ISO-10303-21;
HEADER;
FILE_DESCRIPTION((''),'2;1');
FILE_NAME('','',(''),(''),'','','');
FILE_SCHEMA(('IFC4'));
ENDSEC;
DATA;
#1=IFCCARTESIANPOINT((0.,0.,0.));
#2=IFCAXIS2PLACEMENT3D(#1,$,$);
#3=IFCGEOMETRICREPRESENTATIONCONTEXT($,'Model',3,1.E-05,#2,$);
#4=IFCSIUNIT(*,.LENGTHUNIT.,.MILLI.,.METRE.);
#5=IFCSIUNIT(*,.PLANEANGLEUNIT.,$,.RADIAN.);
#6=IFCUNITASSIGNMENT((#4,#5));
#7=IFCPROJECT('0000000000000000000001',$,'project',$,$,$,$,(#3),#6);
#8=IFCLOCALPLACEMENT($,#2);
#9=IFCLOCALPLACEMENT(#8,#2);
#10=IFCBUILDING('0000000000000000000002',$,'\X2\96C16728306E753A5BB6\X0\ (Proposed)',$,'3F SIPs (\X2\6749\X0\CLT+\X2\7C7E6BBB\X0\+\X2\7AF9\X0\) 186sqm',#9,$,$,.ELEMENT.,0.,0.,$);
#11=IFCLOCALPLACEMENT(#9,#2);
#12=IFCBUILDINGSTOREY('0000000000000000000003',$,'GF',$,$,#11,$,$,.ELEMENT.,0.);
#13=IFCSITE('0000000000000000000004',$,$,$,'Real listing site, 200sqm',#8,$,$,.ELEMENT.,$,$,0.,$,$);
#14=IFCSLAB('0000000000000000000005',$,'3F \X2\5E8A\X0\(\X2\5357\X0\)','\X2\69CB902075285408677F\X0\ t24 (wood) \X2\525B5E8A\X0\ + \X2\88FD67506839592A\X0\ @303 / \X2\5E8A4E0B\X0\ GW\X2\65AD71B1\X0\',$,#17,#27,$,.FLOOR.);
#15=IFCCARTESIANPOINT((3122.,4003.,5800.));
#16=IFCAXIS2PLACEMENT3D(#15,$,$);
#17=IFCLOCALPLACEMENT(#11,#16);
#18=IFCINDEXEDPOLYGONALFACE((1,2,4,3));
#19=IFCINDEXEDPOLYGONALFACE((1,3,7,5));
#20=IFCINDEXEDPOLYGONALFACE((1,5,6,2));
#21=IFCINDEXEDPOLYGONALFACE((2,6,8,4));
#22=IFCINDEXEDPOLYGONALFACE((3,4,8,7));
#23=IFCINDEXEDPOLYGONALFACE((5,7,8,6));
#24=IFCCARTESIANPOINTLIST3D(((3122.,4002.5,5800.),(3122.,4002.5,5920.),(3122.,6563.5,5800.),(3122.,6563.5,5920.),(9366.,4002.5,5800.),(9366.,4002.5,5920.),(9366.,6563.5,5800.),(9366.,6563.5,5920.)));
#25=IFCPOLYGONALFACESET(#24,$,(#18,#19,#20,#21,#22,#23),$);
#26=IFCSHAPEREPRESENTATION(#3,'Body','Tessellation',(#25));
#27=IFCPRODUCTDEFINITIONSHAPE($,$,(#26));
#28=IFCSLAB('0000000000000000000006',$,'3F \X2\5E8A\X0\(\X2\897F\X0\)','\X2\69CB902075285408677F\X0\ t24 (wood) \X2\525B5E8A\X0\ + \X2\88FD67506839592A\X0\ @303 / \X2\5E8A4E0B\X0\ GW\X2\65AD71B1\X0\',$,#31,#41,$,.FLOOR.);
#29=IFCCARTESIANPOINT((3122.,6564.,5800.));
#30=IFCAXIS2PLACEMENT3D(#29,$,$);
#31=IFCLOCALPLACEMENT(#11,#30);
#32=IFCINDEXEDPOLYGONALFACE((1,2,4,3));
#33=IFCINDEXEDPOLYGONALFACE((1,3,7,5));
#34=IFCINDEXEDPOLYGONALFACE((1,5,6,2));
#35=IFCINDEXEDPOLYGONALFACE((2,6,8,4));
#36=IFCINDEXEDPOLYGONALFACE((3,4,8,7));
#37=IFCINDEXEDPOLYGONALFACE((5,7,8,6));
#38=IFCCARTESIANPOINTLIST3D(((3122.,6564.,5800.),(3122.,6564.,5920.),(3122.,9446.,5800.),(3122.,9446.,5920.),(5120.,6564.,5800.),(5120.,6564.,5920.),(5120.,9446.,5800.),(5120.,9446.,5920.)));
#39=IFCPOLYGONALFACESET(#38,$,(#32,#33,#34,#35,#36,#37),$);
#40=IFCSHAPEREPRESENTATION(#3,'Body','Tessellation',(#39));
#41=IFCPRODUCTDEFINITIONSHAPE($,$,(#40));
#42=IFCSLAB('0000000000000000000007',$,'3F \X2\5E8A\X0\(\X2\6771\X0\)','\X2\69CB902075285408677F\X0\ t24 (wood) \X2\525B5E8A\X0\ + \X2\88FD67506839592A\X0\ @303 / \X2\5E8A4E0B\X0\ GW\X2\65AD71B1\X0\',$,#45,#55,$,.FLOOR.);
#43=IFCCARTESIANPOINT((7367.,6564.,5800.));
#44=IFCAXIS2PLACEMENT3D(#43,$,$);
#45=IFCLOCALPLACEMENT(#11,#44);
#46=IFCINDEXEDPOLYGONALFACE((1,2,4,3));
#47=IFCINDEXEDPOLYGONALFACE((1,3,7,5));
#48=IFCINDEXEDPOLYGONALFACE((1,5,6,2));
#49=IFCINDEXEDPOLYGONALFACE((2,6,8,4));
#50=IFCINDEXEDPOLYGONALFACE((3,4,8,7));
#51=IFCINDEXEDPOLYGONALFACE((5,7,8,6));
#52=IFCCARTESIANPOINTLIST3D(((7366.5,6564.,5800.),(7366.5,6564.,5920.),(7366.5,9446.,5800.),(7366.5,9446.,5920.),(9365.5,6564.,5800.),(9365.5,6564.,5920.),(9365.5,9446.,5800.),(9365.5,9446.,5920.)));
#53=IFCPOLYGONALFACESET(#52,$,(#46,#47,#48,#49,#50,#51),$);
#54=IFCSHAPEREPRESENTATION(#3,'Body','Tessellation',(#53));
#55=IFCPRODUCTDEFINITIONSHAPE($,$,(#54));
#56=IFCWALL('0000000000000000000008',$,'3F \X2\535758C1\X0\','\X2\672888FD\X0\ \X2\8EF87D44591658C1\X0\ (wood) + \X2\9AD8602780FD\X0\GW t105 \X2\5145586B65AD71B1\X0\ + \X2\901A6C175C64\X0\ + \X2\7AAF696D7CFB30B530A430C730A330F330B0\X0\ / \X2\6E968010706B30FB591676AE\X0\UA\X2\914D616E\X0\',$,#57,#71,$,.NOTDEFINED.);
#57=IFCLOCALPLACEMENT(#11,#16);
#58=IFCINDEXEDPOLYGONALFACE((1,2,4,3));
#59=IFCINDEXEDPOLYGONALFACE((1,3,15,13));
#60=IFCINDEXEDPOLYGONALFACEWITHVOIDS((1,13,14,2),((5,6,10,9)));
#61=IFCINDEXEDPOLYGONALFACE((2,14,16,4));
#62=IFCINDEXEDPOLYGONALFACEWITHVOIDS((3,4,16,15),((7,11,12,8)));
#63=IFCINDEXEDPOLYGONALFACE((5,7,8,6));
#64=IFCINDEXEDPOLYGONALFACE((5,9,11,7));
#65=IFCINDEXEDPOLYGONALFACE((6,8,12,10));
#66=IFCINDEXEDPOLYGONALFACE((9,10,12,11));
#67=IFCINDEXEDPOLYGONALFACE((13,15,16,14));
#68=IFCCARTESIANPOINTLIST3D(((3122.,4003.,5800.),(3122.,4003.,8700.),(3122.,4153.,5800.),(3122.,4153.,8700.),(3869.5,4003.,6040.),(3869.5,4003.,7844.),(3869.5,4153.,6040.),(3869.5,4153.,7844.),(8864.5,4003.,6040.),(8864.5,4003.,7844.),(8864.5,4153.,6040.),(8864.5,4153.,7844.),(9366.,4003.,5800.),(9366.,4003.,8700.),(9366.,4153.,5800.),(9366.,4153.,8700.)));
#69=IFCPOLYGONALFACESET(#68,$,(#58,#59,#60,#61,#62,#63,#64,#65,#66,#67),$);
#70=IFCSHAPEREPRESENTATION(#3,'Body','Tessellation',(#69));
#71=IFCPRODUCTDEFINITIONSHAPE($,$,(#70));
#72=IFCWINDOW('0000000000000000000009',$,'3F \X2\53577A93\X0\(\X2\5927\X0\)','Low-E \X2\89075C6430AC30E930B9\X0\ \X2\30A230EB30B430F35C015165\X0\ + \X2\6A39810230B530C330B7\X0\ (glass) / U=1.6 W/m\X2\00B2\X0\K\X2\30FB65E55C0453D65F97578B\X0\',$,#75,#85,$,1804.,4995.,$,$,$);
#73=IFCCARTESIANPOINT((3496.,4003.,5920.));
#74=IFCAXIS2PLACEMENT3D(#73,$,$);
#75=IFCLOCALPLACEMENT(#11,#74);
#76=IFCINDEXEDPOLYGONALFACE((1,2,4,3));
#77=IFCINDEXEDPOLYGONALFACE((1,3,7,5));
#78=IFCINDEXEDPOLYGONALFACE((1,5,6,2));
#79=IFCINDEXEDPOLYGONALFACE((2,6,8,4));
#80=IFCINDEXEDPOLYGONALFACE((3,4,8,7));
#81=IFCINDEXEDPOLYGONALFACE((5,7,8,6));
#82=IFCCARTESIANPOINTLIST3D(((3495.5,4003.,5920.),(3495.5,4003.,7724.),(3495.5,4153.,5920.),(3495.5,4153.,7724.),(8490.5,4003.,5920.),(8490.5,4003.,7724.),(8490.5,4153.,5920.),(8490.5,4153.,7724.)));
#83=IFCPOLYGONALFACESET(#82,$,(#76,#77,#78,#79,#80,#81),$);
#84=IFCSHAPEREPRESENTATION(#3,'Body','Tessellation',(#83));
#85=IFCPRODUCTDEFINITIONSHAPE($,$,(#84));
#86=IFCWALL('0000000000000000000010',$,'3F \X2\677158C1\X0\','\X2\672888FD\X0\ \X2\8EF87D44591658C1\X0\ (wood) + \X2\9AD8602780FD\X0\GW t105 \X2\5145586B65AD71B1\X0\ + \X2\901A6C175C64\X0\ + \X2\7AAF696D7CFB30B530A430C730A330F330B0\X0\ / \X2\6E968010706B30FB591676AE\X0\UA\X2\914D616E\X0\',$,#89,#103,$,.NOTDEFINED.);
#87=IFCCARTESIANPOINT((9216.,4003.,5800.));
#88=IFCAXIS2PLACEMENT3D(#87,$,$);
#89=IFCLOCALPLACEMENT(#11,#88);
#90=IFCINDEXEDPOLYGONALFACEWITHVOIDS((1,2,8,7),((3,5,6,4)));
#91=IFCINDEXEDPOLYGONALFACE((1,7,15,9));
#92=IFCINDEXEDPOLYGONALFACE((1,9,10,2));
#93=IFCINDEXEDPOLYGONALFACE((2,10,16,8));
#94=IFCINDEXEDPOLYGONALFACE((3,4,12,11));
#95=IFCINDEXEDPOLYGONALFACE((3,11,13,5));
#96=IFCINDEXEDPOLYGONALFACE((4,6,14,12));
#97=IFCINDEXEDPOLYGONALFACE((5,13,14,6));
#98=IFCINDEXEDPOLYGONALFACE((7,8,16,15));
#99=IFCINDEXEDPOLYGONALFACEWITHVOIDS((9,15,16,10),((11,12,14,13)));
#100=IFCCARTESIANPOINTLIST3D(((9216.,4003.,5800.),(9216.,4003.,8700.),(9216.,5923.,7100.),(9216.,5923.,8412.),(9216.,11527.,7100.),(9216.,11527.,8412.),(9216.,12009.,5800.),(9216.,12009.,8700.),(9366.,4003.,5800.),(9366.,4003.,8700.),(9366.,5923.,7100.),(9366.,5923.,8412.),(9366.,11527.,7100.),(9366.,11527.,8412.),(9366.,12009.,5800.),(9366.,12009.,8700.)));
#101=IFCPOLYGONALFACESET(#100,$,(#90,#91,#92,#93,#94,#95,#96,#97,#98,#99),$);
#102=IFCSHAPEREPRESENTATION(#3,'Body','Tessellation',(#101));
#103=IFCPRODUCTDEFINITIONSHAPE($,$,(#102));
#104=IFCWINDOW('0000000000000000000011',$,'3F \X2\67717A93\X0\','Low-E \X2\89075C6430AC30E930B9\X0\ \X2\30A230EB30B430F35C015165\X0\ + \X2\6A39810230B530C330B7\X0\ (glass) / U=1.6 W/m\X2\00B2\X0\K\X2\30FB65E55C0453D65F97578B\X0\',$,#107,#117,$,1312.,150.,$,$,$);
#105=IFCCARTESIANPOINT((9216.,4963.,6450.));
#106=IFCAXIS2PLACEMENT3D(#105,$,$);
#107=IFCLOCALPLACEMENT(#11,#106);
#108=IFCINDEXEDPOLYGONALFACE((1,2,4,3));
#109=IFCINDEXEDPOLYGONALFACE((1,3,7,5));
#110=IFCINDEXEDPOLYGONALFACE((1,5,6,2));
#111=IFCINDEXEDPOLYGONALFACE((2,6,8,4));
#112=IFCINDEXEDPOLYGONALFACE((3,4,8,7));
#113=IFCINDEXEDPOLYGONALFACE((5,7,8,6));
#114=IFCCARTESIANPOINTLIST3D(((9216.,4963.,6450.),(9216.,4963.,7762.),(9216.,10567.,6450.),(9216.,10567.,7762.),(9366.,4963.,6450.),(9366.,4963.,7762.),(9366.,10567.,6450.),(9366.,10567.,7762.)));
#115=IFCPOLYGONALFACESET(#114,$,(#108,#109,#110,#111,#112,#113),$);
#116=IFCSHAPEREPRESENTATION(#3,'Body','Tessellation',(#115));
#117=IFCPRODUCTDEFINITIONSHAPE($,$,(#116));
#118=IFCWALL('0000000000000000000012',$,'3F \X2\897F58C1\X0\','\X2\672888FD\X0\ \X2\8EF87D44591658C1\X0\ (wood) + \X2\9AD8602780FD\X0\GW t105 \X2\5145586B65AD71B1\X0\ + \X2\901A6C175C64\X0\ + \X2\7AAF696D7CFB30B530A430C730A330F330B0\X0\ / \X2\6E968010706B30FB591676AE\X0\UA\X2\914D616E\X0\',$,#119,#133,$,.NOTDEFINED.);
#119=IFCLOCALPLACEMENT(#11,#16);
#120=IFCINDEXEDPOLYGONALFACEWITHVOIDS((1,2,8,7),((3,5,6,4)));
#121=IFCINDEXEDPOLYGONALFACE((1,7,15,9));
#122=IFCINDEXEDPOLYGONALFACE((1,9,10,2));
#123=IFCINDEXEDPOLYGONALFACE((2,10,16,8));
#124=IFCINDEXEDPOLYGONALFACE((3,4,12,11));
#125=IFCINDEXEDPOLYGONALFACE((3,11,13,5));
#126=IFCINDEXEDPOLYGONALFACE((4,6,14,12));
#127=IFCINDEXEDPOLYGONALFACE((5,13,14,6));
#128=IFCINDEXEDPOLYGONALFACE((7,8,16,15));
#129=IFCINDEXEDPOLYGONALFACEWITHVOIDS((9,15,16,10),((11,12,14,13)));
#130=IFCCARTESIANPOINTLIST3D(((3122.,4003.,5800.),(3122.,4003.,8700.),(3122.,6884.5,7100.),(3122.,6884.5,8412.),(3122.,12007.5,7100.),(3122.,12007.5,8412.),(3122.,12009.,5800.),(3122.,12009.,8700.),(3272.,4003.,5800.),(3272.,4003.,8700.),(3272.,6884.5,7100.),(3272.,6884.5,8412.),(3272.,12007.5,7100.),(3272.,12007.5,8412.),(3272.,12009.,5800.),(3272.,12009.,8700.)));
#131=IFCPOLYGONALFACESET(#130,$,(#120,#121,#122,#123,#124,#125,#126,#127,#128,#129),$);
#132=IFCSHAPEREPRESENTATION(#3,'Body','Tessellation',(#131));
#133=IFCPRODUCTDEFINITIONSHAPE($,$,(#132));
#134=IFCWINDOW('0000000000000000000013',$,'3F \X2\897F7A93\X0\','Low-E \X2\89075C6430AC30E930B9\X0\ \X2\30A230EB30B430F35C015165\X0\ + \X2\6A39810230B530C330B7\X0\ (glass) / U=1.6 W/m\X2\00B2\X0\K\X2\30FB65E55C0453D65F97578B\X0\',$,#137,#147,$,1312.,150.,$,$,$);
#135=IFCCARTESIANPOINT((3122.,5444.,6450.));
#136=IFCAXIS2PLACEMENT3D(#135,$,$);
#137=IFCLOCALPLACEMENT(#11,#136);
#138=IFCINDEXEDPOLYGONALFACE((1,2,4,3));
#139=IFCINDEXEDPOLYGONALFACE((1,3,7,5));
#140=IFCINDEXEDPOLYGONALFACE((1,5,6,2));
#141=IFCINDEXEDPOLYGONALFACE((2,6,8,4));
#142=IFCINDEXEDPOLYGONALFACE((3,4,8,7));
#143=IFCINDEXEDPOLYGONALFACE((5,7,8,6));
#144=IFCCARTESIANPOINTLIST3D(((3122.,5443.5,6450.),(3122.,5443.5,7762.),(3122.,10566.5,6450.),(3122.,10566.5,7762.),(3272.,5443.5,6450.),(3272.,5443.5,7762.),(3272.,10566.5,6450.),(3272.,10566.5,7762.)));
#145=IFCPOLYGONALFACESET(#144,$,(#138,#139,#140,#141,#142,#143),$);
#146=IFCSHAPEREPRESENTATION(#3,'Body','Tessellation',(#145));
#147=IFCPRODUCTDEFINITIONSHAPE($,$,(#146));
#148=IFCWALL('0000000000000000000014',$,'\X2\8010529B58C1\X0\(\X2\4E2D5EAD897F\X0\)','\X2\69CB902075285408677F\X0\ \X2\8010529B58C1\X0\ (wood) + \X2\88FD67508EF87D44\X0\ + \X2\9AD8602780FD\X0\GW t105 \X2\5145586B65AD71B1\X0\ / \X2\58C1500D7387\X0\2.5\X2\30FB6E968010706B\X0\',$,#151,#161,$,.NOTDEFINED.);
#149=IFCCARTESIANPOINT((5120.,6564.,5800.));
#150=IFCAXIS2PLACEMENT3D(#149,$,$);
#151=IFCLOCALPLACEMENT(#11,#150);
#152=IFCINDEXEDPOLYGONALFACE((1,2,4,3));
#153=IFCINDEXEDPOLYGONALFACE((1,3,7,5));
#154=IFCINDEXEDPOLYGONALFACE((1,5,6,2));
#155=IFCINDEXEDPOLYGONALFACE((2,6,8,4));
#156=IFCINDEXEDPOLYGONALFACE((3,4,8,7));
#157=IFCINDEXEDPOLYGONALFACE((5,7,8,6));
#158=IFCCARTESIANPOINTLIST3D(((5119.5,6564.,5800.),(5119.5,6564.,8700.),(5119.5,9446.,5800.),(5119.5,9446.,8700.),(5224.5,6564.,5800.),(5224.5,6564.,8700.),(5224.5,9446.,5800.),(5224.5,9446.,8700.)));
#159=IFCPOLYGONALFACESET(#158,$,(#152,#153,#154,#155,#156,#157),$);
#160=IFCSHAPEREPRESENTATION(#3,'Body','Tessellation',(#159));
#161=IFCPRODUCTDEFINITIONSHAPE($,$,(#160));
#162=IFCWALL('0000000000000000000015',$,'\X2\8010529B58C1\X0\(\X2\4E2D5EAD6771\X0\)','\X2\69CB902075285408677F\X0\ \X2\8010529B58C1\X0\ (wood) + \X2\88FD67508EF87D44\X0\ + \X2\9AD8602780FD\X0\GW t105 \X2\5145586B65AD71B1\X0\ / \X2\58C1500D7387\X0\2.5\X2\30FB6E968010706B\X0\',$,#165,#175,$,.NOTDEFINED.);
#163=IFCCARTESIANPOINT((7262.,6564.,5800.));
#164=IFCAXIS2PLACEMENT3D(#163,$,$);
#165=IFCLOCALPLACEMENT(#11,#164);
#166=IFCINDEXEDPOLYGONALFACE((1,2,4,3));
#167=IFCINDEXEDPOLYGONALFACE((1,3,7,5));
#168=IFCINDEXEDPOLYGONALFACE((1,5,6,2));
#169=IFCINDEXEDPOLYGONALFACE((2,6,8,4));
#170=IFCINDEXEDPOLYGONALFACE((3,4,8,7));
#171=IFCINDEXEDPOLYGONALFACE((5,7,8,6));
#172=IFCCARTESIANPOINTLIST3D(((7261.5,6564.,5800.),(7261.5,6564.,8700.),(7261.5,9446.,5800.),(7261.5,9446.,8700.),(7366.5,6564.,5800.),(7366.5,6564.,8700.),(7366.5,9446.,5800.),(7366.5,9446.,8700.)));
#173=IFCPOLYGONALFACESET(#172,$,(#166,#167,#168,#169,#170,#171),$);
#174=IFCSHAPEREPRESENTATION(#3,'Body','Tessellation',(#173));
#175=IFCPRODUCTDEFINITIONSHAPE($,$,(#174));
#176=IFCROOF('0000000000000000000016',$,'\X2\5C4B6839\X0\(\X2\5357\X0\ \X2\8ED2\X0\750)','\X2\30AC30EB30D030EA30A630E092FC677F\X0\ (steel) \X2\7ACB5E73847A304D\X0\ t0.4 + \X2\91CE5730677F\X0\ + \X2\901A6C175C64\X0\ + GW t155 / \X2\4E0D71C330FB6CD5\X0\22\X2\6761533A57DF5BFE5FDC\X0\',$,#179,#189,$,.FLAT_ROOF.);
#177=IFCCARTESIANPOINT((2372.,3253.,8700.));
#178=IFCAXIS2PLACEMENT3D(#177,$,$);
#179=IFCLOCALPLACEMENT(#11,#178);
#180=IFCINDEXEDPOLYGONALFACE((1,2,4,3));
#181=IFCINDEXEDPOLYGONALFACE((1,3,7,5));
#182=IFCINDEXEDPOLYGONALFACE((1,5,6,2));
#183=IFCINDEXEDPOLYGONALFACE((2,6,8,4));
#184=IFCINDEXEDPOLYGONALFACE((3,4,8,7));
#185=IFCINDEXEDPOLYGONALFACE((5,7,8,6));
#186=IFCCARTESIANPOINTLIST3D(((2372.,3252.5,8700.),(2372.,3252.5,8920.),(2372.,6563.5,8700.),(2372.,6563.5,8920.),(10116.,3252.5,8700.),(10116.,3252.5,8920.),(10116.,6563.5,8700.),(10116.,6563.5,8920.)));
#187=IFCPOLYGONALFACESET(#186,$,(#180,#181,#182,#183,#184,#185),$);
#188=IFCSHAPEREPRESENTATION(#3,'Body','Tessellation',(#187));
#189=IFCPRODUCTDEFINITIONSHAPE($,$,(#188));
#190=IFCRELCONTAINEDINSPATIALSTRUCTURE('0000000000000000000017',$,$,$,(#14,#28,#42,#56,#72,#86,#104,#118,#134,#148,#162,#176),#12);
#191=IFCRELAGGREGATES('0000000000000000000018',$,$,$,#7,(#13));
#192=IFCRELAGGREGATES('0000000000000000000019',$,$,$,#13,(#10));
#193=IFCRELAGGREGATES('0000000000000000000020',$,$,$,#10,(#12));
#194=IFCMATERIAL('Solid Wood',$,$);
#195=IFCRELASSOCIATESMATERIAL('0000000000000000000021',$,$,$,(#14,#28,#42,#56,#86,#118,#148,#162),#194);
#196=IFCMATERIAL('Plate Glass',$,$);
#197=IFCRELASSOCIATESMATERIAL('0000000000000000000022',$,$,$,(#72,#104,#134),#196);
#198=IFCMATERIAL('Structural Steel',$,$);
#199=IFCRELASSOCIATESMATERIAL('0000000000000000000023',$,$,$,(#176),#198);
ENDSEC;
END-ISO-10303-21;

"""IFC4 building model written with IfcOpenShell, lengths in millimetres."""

from ifc_helpers import new_model, si_unit, frame, frame_2d, origin, place, context, project, spatial, rectangle, extrude, material, element, fill, save


model = new_model("IFC4")

# Units and contexts
model_context = context("Model", 3, precision=1e-05, world=origin())
ifc_project = project(units=[si_unit("LENGTHUNIT", "METRE", prefix="MILLI"), si_unit("PLANEANGLEUNIT", "RADIAN")], contexts=[model_context])

# Site, building, storey
site_placement = place(None, origin())
site = spatial("IfcSite", under=ifc_project, at=site_placement, ObjectType="Real listing site, 200sqm", CompositionType="ELEMENT", RefElevation=0.0)
building_placement = place(site_placement, origin())
building = spatial("IfcBuilding", under=site, at=building_placement, Name="雁木の町家 (Proposed)", ObjectType="3F SIPs (杉CLT+籾殻+竹) 186sqm", CompositionType="ELEMENT", ElevationOfRefHeight=0.0, ElevationOfTerrain=0.0)
storey_placement = place(building_placement, origin())
storey = spatial("IfcBuildingStorey", under=building, at=storey_placement, Name="GF", CompositionType="ELEMENT", Elevation=0.0)

# Slabs
ifc_material_1 = material(Name="Solid Wood")
slab_1_placement = place(storey_placement, frame((3122.0, 4003.0, 5800.0)))
element("IfcSlab", 1, at=slab_1_placement, inside=storey, material=ifc_material_1, Name="3F 床(南)", Description="構造用合板 t24 (wood) 剛床 + 製材根太 @303 / 床下 GW断熱", PredefinedType="FLOOR", context=model_context, shape_type="SweptSolid", body=[
    extrude(rectangle(XDim=6244.0, YDim=2561.0, at=frame_2d((3122.0, 1280.0))), frame((3122.0, 4003.0, 5800.0)), (0.0, 0.0, 1.0), 120.0),
])
slab_2_placement = place(storey_placement, frame((3122.0, 6564.0, 5800.0)))
element("IfcSlab", 2, at=slab_2_placement, inside=storey, material=ifc_material_1, Name="3F 床(西)", Description="構造用合板 t24 (wood) 剛床 + 製材根太 @303 / 床下 GW断熱", PredefinedType="FLOOR", context=model_context, shape_type="SweptSolid", body=[
    extrude(rectangle(XDim=1998.0, YDim=2882.0, at=frame_2d((999.0, 1441.0))), frame((3122.0, 6564.0, 5800.0)), (0.0, 0.0, 1.0), 120.0),
])
slab_3_placement = place(storey_placement, frame((7367.0, 6564.0, 5800.0)))
element("IfcSlab", 3, at=slab_3_placement, inside=storey, material=ifc_material_1, Name="3F 床(東)", Description="構造用合板 t24 (wood) 剛床 + 製材根太 @303 / 床下 GW断熱", PredefinedType="FLOOR", context=model_context, shape_type="SweptSolid", body=[
    extrude(rectangle(XDim=1999.0, YDim=2882.0, at=frame_2d((999.0, 1441.0))), frame((7367.0, 6564.0, 5800.0)), (0.0, 0.0, 1.0), 120.0),
])

# Walls, openings, windows
wall_1_placement = place(storey_placement, frame((3122.0, 4003.0, 5800.0)))
wall_1 = element("IfcWall", 4, at=wall_1_placement, inside=storey, material=ifc_material_1, Name="3F 南壁", Description="木製 軸組外壁 (wood) + 高性能GW t105 充填断熱 + 通気層 + 窯業系サイディング / 準耐火・外皮UA配慮", PredefinedType="NOTDEFINED", context=model_context, shape_type="SweptSolid", body=[
    extrude(rectangle(XDim=6244.0, YDim=150.0, at=frame_2d((3122.0, 75.0))), frame((3122.0, 4003.0, 5800.0)), (0.0, 0.0, 1.0), 2900.0),
])
opening_1_placement = place(storey_placement, frame((3496.0, 4003.0, 5920.0)))
opening_1 = element("IfcOpeningElement", 5, at=opening_1_placement, cuts=wall_1, PredefinedType="NOTDEFINED", context=model_context, shape_type="SweptSolid", body=[
    extrude(rectangle(XDim=4995.0, YDim=150.0, at=frame_2d((2497.0, 75.0))), frame((3496.0, 4003.0, 5920.0)), (0.0, 0.0, 1.0), 1804.0),
])
ifc_material_2 = material(Name="Plate Glass")
window_1_placement = place(storey_placement, frame((3496.0, 4003.0, 5920.0)))
window_1 = element("IfcWindow", 6, at=window_1_placement, inside=storey, material=ifc_material_2, Name="3F 南窓(大)", Description="Low-E 複層ガラス アルゴン封入 + 樹脂サッシ (glass) / U=1.6 W/m²K・日射取得型", OverallHeight=1804.0, OverallWidth=4995.0, context=model_context, shape_type="SweptSolid", body=[
    extrude(rectangle(XDim=4995.0, YDim=150.0, at=frame_2d((2497.0, 75.0))), frame((3496.0, 4003.0, 5920.0)), (0.0, 0.0, 1.0), 1804.0),
])
fill(opening_1, window_1)
wall_2_placement = place(storey_placement, frame((9216.0, 4003.0, 5800.0)))
wall_2 = element("IfcWall", 7, at=wall_2_placement, inside=storey, material=ifc_material_1, Name="3F 東壁", Description="木製 軸組外壁 (wood) + 高性能GW t105 充填断熱 + 通気層 + 窯業系サイディング / 準耐火・外皮UA配慮", PredefinedType="NOTDEFINED", context=model_context, shape_type="SweptSolid", body=[
    extrude(rectangle(XDim=150.0, YDim=8006.0, at=frame_2d((75.0, 4003.0))), frame((9216.0, 4003.0, 5800.0)), (0.0, 0.0, 1.0), 2900.0),
])
opening_2_placement = place(storey_placement, frame((9216.0, 4963.0, 6450.0)))
opening_2 = element("IfcOpeningElement", 8, at=opening_2_placement, cuts=wall_2, PredefinedType="NOTDEFINED", context=model_context, shape_type="SweptSolid", body=[
    extrude(rectangle(XDim=150.0, YDim=5604.0, at=frame_2d((75.0, 2802.0))), frame((9216.0, 4963.0, 6450.0)), (0.0, 0.0, 1.0), 1312.0),
])
window_2_placement = place(storey_placement, frame((9216.0, 4963.0, 6450.0)))
window_2 = element("IfcWindow", 9, at=window_2_placement, inside=storey, material=ifc_material_2, Name="3F 東窓", Description="Low-E 複層ガラス アルゴン封入 + 樹脂サッシ (glass) / U=1.6 W/m²K・日射取得型", OverallHeight=1312.0, OverallWidth=150.0, context=model_context, shape_type="SweptSolid", body=[
    extrude(rectangle(XDim=150.0, YDim=5604.0, at=frame_2d((75.0, 2802.0))), frame((9216.0, 4963.0, 6450.0)), (0.0, 0.0, 1.0), 1312.0),
])
fill(opening_2, window_2)
wall_3_placement = place(storey_placement, frame((3122.0, 4003.0, 5800.0)))
wall_3 = element("IfcWall", 10, at=wall_3_placement, inside=storey, material=ifc_material_1, Name="3F 西壁", Description="木製 軸組外壁 (wood) + 高性能GW t105 充填断熱 + 通気層 + 窯業系サイディング / 準耐火・外皮UA配慮", PredefinedType="NOTDEFINED", context=model_context, shape_type="SweptSolid", body=[
    extrude(rectangle(XDim=150.0, YDim=8006.0, at=frame_2d((75.0, 4003.0))), frame((3122.0, 4003.0, 5800.0)), (0.0, 0.0, 1.0), 2900.0),
])
opening_3_placement = place(storey_placement, frame((3122.0, 5444.0, 6450.0)))
opening_3 = element("IfcOpeningElement", 11, at=opening_3_placement, cuts=wall_3, PredefinedType="NOTDEFINED", context=model_context, shape_type="SweptSolid", body=[
    extrude(rectangle(XDim=150.0, YDim=5123.0, at=frame_2d((75.0, 2561.0))), frame((3122.0, 5444.0, 6450.0)), (0.0, 0.0, 1.0), 1312.0),
])
window_3_placement = place(storey_placement, frame((3122.0, 5444.0, 6450.0)))
window_3 = element("IfcWindow", 12, at=window_3_placement, inside=storey, material=ifc_material_2, Name="3F 西窓", Description="Low-E 複層ガラス アルゴン封入 + 樹脂サッシ (glass) / U=1.6 W/m²K・日射取得型", OverallHeight=1312.0, OverallWidth=150.0, context=model_context, shape_type="SweptSolid", body=[
    extrude(rectangle(XDim=150.0, YDim=5123.0, at=frame_2d((75.0, 2561.0))), frame((3122.0, 5444.0, 6450.0)), (0.0, 0.0, 1.0), 1312.0),
])
fill(opening_3, window_3)

# Walls
wall_4_placement = place(storey_placement, frame((5120.0, 6564.0, 5800.0)))
element("IfcWall", 13, at=wall_4_placement, inside=storey, material=ifc_material_1, Name="耐力壁(中庭西)", Description="構造用合板 耐力壁 (wood) + 製材軸組 + 高性能GW t105 充填断熱 / 壁倍率2.5・準耐火", PredefinedType="NOTDEFINED", context=model_context, shape_type="SweptSolid", body=[
    extrude(rectangle(XDim=105.0, YDim=2882.0, at=frame_2d((52.0, 1441.0))), frame((5120.0, 6564.0, 5800.0)), (0.0, 0.0, 1.0), 2900.0),
])
wall_5_placement = place(storey_placement, frame((7262.0, 6564.0, 5800.0)))
element("IfcWall", 14, at=wall_5_placement, inside=storey, material=ifc_material_1, Name="耐力壁(中庭東)", Description="構造用合板 耐力壁 (wood) + 製材軸組 + 高性能GW t105 充填断熱 / 壁倍率2.5・準耐火", PredefinedType="NOTDEFINED", context=model_context, shape_type="SweptSolid", body=[
    extrude(rectangle(XDim=105.0, YDim=2882.0, at=frame_2d((52.0, 1441.0))), frame((7262.0, 6564.0, 5800.0)), (0.0, 0.0, 1.0), 2900.0),
])

# Roof
ifc_material_3 = material(Name="Structural Steel")
roof_1_placement = place(storey_placement, frame((2372.0, 3253.0, 8700.0)))
element("IfcRoof", 15, at=roof_1_placement, inside=storey, material=ifc_material_3, Name="屋根(南 軒750)", Description="ガルバリウム鋼板 (steel) 立平葺き t0.4 + 野地板 + 通気層 + GW t155 / 不燃・法22条区域対応", PredefinedType="FLAT_ROOF", context=model_context, shape_type="SweptSolid", body=[
    extrude(rectangle(XDim=7744.0, YDim=3311.0, at=frame_2d((3872.0, 1655.0))), frame((2372.0, 3253.0, 8700.0)), (0.0, 0.0, 1.0), 220.0),
])

save(model, "model.ifc")
